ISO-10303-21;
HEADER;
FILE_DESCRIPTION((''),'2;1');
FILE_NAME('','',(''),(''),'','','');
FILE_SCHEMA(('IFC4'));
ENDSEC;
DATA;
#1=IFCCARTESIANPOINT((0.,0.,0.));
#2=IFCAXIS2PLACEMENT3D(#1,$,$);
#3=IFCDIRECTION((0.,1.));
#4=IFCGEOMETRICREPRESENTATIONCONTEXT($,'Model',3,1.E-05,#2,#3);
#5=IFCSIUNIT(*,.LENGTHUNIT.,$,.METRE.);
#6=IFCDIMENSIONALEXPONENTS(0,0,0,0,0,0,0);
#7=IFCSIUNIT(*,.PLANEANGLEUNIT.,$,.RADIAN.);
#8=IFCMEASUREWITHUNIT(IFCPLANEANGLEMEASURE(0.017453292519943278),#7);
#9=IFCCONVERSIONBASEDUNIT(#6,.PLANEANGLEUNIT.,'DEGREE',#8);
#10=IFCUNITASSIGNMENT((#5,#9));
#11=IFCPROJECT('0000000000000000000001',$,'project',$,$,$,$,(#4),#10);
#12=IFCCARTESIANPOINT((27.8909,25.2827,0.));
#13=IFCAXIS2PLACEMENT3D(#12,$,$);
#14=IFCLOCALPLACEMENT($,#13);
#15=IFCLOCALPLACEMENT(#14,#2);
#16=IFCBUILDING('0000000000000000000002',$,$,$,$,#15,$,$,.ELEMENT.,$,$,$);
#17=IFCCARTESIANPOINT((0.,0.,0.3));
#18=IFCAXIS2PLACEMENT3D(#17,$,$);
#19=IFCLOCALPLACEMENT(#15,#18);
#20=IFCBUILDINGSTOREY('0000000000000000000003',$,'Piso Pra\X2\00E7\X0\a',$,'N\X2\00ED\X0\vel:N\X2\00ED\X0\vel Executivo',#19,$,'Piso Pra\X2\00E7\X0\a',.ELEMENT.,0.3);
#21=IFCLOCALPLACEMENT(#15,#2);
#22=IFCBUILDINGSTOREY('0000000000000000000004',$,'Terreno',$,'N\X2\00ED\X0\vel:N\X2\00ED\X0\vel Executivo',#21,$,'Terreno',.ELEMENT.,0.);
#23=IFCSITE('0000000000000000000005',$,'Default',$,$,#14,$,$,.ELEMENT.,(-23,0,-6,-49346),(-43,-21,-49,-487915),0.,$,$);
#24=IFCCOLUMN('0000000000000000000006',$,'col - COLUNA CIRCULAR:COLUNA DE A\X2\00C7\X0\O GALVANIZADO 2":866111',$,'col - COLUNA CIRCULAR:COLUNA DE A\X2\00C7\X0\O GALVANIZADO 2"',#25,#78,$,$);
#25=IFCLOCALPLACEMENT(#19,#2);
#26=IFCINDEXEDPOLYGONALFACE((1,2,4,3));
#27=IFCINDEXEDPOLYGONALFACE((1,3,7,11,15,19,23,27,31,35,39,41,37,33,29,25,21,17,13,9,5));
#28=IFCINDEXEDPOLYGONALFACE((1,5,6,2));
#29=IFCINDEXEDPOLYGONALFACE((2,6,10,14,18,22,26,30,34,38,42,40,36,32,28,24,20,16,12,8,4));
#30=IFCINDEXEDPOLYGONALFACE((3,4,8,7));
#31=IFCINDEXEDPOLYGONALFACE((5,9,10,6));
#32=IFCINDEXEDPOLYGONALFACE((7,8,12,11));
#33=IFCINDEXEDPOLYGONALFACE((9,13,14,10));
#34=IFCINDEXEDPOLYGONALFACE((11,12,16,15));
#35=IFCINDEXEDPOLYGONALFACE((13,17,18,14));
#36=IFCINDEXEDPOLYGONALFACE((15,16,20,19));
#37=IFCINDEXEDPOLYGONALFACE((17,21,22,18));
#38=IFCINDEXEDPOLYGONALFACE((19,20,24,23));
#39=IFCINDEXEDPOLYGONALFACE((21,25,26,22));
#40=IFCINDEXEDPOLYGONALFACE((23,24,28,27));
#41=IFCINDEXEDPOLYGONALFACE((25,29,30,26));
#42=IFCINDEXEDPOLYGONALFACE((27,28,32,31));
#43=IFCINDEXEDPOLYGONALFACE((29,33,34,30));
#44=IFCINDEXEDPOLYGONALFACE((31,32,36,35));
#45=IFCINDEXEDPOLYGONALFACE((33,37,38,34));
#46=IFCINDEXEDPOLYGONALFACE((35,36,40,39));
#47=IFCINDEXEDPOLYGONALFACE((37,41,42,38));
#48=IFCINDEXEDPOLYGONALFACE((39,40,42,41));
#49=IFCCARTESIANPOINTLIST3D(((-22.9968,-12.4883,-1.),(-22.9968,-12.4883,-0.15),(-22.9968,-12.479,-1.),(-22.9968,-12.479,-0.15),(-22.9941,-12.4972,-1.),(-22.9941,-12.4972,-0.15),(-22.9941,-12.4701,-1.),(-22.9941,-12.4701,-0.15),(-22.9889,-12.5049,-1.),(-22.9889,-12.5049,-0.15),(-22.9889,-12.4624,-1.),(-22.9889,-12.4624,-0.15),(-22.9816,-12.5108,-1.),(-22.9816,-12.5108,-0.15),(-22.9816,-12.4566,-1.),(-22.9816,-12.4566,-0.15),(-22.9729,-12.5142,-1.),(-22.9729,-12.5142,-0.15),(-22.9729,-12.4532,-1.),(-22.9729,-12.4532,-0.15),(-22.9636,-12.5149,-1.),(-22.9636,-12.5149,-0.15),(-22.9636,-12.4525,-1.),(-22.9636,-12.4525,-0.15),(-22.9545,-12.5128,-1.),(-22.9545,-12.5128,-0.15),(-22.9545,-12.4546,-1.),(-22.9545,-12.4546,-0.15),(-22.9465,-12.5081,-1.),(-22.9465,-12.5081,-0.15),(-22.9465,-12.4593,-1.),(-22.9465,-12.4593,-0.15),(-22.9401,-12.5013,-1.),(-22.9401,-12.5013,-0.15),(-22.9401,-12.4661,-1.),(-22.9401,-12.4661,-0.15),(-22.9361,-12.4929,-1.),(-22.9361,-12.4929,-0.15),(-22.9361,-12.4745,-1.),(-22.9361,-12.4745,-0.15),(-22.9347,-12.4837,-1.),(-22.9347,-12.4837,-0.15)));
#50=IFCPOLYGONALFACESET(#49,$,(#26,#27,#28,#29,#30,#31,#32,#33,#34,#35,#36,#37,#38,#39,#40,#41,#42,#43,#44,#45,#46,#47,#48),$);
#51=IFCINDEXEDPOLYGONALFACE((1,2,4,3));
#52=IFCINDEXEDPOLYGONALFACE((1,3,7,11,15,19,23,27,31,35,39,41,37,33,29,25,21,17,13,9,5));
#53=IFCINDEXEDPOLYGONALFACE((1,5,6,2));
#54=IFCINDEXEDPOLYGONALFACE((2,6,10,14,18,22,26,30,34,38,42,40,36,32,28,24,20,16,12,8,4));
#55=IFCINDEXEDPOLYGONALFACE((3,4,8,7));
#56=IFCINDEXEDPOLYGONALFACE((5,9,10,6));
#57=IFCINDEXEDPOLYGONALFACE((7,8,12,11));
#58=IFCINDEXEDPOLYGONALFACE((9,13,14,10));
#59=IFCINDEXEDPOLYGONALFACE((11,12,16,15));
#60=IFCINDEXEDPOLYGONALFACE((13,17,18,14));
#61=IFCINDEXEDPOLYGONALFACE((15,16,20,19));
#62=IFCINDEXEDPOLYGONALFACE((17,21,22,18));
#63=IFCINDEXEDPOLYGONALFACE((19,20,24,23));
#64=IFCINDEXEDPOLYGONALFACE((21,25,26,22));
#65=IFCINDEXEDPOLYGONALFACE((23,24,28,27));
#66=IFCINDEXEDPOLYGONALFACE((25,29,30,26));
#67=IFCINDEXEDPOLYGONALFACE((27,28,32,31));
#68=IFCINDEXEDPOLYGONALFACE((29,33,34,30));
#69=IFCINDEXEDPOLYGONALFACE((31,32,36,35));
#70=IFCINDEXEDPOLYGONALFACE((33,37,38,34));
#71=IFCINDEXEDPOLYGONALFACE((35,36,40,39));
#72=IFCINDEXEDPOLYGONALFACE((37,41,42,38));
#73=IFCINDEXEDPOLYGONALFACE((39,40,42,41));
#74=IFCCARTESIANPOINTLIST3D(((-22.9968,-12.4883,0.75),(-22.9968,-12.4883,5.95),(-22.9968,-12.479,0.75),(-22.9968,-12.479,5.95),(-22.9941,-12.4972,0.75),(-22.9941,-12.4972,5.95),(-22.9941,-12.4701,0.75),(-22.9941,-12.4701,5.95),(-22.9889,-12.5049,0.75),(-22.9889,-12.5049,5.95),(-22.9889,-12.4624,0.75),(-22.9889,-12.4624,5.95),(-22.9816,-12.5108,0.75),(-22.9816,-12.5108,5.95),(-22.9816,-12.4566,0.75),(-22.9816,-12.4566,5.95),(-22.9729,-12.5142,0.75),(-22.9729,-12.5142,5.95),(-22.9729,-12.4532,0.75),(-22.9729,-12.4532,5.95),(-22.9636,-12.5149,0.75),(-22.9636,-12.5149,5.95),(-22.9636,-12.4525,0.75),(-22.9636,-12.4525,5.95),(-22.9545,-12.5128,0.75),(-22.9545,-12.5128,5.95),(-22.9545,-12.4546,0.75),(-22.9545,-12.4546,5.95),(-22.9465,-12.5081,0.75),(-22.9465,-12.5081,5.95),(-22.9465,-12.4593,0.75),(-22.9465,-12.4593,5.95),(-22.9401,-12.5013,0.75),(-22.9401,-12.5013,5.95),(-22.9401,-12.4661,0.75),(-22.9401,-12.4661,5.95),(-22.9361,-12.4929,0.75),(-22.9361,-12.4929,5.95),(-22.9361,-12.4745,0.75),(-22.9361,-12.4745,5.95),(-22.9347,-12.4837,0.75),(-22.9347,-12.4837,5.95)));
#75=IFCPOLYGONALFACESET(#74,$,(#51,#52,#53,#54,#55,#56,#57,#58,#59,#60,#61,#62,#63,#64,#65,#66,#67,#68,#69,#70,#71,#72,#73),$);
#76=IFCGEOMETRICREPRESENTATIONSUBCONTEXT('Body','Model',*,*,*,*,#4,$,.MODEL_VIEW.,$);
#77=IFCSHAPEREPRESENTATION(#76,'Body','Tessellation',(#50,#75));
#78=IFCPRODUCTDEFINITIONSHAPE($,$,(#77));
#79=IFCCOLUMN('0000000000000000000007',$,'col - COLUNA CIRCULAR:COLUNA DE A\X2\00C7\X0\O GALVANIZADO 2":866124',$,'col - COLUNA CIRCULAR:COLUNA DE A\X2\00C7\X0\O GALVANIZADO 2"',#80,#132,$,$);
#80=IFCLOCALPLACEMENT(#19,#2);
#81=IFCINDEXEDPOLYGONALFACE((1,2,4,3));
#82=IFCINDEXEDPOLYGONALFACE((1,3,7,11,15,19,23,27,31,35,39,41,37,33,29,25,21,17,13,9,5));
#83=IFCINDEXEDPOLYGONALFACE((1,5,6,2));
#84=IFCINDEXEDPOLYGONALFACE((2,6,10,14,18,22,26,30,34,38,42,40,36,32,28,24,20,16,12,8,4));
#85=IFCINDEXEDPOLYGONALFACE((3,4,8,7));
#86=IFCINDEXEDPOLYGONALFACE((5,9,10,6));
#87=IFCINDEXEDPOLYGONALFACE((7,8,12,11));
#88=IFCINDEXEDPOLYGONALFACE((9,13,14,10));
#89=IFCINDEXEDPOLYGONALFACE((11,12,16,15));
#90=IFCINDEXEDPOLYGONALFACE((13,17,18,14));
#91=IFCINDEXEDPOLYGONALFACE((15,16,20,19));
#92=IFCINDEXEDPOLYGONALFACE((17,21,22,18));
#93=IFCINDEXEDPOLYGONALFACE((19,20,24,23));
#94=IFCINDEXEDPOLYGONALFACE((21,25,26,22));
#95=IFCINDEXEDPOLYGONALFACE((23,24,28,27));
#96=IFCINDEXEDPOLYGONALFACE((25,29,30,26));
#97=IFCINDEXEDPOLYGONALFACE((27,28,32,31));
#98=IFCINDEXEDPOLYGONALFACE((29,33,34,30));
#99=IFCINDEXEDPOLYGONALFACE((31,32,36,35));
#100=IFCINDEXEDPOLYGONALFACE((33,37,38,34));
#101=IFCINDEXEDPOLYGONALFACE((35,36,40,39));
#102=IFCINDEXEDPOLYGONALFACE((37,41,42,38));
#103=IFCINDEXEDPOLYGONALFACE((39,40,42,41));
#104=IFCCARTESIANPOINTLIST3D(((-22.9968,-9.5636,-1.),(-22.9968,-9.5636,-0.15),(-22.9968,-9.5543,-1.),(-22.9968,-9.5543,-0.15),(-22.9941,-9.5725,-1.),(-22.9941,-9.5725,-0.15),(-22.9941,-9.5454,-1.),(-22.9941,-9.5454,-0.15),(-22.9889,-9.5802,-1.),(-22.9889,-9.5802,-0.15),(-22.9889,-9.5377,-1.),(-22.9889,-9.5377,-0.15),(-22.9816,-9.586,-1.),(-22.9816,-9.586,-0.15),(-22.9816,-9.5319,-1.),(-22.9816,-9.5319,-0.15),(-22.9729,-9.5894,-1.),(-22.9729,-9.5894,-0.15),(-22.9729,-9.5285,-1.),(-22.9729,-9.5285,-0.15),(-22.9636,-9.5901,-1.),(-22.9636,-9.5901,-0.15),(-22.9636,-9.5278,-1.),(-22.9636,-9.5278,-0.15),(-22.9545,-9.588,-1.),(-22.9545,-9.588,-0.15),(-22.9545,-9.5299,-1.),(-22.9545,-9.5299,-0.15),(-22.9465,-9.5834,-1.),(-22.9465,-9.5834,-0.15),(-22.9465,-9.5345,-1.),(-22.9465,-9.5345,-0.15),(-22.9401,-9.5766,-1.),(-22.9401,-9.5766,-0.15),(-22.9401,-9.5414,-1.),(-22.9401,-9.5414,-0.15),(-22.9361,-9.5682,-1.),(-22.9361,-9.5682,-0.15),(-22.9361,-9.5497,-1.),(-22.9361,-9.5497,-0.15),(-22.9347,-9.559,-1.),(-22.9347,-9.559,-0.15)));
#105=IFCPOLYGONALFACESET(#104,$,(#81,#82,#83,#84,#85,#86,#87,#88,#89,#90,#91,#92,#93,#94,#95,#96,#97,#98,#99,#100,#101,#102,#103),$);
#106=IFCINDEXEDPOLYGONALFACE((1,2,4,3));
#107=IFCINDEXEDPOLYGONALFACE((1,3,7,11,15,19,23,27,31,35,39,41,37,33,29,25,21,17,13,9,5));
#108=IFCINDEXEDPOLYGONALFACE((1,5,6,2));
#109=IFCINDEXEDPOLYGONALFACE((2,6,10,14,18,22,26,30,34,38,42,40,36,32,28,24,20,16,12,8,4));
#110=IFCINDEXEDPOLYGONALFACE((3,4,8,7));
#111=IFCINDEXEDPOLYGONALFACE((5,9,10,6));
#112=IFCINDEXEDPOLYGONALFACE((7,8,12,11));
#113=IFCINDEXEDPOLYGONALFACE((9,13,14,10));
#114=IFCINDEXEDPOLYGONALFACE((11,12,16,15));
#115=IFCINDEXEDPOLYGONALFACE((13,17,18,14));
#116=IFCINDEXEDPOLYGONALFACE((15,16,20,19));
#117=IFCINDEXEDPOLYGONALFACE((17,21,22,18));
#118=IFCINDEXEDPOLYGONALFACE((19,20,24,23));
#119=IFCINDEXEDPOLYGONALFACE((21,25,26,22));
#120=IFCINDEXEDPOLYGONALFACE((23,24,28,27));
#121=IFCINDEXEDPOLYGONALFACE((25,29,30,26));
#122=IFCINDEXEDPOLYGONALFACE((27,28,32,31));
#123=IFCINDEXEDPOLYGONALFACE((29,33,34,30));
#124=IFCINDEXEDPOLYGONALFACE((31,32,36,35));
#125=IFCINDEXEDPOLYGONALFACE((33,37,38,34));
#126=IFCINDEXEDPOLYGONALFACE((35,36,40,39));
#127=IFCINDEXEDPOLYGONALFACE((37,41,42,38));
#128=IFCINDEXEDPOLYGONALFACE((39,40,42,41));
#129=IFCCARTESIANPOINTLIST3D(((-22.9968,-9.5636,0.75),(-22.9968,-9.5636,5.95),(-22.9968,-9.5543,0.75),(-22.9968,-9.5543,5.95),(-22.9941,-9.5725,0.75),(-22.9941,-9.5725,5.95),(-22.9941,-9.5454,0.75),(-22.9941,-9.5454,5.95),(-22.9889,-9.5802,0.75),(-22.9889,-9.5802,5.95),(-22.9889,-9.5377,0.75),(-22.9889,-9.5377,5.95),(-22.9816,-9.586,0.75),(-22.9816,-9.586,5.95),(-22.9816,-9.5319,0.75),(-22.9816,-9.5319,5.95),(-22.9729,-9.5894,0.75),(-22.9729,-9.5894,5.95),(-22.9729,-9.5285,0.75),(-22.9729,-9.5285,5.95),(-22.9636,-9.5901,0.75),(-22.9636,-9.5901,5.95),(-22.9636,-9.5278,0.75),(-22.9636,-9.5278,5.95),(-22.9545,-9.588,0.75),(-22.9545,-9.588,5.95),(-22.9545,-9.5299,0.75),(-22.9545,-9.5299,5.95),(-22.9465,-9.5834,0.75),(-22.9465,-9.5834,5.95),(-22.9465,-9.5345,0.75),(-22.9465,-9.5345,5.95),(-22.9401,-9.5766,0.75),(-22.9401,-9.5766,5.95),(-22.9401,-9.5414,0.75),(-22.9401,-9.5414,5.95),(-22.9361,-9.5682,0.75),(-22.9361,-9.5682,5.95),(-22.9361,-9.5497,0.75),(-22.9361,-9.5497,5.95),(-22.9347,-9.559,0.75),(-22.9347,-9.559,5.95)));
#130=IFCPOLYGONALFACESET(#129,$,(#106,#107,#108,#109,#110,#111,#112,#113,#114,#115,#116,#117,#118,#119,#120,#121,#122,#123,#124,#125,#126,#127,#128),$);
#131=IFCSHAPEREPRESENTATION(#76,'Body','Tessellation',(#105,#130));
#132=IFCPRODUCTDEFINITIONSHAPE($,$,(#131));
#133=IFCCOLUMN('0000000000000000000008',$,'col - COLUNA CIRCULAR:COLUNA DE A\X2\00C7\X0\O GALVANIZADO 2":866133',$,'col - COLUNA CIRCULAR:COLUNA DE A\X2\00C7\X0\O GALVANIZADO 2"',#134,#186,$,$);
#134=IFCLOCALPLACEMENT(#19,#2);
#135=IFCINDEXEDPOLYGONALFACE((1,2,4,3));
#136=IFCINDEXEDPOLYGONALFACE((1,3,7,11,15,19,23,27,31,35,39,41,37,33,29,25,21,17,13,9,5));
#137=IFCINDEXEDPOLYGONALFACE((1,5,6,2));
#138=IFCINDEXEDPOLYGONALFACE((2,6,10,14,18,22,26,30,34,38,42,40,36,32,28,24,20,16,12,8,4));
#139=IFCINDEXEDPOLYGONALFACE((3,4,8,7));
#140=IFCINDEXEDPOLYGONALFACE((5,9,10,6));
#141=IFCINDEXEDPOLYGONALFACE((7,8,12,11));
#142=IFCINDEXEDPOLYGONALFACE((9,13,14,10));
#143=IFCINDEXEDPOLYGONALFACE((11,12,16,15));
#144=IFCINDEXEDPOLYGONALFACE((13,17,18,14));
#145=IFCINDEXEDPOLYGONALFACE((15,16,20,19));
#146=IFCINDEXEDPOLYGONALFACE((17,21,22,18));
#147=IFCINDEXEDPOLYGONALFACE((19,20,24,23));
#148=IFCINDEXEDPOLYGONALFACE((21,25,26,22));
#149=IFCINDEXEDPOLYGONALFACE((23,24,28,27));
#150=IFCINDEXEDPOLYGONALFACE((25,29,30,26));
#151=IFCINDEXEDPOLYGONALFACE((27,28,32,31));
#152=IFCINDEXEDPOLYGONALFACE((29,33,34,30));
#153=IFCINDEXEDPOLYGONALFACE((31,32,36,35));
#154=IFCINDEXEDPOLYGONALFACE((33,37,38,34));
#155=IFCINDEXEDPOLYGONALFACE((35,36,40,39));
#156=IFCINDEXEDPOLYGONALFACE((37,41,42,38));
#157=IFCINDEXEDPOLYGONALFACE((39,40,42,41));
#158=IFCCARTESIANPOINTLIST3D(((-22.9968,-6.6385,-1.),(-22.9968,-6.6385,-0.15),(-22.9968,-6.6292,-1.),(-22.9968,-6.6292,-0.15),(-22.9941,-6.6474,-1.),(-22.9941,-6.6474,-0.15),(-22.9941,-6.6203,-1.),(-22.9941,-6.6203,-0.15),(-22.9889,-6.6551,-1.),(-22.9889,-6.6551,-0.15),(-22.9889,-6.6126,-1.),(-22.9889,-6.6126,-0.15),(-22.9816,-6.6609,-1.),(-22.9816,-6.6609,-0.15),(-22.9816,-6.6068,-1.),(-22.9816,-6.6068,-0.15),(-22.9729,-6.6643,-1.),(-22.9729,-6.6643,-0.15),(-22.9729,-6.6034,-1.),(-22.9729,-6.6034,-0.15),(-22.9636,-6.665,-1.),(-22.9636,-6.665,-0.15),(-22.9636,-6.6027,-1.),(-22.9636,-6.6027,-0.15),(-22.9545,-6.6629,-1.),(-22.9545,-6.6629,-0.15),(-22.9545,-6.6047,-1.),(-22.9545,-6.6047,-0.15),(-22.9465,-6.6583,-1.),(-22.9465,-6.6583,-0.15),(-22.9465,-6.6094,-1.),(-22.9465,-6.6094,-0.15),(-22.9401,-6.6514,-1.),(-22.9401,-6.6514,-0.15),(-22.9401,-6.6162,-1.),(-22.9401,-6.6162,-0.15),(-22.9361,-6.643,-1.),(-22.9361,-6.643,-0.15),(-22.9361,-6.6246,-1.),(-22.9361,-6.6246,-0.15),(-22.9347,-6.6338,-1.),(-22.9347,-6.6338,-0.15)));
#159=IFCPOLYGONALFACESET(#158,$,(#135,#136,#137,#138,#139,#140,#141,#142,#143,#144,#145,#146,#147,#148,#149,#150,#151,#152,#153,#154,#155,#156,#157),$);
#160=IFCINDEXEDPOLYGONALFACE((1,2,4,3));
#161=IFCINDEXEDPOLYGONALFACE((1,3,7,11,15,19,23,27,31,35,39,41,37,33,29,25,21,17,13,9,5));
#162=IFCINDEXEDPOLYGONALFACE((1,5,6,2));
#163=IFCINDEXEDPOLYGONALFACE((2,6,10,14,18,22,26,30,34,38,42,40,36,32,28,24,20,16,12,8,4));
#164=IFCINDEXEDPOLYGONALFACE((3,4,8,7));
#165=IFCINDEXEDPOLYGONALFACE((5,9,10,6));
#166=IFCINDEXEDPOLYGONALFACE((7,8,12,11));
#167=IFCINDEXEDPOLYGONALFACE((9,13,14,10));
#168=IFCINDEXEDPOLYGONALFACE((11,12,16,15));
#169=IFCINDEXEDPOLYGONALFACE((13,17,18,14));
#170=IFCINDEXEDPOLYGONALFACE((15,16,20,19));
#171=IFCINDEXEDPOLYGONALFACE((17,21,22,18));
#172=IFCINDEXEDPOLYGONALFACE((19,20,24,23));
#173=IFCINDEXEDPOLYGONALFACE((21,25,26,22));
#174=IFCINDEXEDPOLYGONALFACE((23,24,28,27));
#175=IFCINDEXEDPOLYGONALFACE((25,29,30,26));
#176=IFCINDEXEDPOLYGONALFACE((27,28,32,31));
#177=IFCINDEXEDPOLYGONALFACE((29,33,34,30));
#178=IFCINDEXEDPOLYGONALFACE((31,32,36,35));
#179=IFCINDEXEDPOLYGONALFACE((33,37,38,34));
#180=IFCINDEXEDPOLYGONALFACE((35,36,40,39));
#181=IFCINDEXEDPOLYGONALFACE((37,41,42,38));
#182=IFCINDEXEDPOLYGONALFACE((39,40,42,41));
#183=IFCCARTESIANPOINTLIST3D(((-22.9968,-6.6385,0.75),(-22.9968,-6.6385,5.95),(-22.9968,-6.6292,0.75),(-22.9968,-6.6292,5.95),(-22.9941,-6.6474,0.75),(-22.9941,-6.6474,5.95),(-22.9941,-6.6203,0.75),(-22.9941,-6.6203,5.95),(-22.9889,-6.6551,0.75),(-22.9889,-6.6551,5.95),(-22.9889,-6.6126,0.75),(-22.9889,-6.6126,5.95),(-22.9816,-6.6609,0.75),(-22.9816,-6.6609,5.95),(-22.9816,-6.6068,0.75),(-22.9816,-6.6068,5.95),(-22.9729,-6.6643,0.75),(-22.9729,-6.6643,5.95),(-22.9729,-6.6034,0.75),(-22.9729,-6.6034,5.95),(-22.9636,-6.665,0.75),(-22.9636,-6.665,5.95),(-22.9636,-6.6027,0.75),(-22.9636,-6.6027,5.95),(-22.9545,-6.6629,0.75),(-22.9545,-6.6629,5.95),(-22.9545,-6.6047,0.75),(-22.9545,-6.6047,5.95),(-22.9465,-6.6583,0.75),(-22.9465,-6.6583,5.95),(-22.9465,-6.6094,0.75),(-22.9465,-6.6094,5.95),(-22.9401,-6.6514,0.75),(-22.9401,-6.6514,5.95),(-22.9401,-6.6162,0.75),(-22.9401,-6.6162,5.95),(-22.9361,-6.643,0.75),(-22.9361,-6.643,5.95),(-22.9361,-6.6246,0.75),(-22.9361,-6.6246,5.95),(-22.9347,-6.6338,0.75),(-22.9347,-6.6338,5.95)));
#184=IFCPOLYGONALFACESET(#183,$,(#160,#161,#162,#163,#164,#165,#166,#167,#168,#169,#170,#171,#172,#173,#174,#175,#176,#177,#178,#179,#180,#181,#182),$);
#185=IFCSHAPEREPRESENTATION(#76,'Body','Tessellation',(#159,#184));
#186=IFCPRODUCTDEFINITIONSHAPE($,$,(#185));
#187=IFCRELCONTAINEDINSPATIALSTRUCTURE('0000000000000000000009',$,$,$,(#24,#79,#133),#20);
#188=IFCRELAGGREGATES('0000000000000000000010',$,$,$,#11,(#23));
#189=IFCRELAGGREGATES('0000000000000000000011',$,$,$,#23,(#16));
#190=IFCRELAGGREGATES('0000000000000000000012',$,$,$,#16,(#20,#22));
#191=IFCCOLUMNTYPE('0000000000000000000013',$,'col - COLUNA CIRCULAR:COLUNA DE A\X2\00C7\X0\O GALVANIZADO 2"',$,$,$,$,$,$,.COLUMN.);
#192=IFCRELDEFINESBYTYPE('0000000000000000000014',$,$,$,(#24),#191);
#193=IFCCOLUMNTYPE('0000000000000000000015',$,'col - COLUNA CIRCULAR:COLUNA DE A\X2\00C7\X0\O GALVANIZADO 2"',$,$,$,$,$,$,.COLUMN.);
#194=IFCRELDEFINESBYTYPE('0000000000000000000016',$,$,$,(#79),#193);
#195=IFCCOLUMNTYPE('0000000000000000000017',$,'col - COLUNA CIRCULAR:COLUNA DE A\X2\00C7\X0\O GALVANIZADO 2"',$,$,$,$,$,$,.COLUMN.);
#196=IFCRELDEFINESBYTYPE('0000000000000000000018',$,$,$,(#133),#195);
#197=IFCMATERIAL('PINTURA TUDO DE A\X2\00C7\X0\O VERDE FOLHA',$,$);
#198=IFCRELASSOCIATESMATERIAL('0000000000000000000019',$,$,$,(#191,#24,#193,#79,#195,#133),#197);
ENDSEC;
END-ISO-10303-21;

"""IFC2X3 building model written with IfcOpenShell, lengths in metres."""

from ifc_helpers import new_model, entity, si_unit, converted_unit, direction, frame, origin, origin_2d_with_axis, place, context, subcontext, project, spatial, circle, extrude, source, transform, mapped, material, type_object, type_shapes, element, save


model = new_model("IFC2X3")

# Units and contexts
model_context = context("Model", 3, precision=1e-05, world=origin(), true_north=direction((0.0, 1.0)))
body_context = subcontext(model_context, "Body", "Model", "MODEL_VIEW")
ifc_project = project(units=[si_unit("LENGTHUNIT", "METRE"), converted_unit("PLANEANGLEUNIT", "DEGREE", entity("IfcPlaneAngleMeasure", 0.017453292519943278), si_unit("PLANEANGLEUNIT", "RADIAN"), dimensions=[0, 0, 0, 0, 0, 0, 0])], contexts=[model_context])

# Site, building, storey
site_placement = place(None, frame((27.8909, 25.2827, 0.0)))
site = spatial("IfcSite", under=ifc_project, at=site_placement, Name="Default", CompositionType="ELEMENT", RefLatitude=(-23, 0, -6, -49346), RefLongitude=(-43, -21, -49, -487915), RefElevation=0.0)
building_placement = place(site_placement, origin())
building = spatial("IfcBuilding", under=site, at=building_placement, CompositionType="ELEMENT")
storey_1_placement = place(building_placement, frame((0.0, 0.0, 0.3)))
storey_1 = spatial("IfcBuildingStorey", under=building, at=storey_1_placement, Name="Piso Praça", ObjectType="Nível:Nível Executivo", LongName="Piso Praça", CompositionType="ELEMENT", Elevation=0.3)

# Columns
ifc_material_1 = material(Name="PINTURA TUDO DE AÇO VERDE FOLHA")
column_type_1 = type_object("IfcColumnType", Name="col - COLUNA CIRCULAR:COLUNA DE AÇO GALVANIZADO 2\"", PredefinedType="COLUMN", material=ifc_material_1)
shared_shape_1 = source(origin(), body_context, "Body", "SweptSolid", [
    extrude(circle(Radius=0.0312, at=origin_2d_with_axis()), frame((-22.9659, -12.4837, -0.7)), (0.0, 0.0, 1.0), 0.85),
    extrude(circle(Radius=0.0312, at=origin_2d_with_axis()), frame((-22.9659, -12.4837, 1.05)), (0.0, 0.0, 1.0), 5.2),
])
type_shapes(column_type_1, [shared_shape_1])
column_1_placement = place(storey_1_placement, frame((0.0, 0.0, -0.3)))
element("IfcColumn", 1, at=column_1_placement, inside=storey_1, type_object=column_type_1, material=ifc_material_1, Name="col - COLUNA CIRCULAR:COLUNA DE AÇO GALVANIZADO 2\":866111", ObjectType="col - COLUNA CIRCULAR:COLUNA DE AÇO GALVANIZADO 2\"", context=body_context, shape_type="MappedRepresentation", body=[
    mapped(shared_shape_1, transform((0.0, 0.0, 0.0), scale=1.0)),
])
column_type_2 = type_object("IfcColumnType", Name="col - COLUNA CIRCULAR:COLUNA DE AÇO GALVANIZADO 2\"", PredefinedType="COLUMN", material=ifc_material_1)
shared_shape_2 = source(origin(), body_context, "Body", "SweptSolid", [
    extrude(circle(Radius=0.0312, at=origin_2d_with_axis()), frame((-22.9659, -9.559, -0.7)), (0.0, 0.0, 1.0), 0.85),
    extrude(circle(Radius=0.0312, at=origin_2d_with_axis()), frame((-22.9659, -9.559, 1.05)), (0.0, 0.0, 1.0), 5.2),
])
type_shapes(column_type_2, [shared_shape_2])
column_2_placement = place(storey_1_placement, frame((0.0, 0.0, -0.3)))
element("IfcColumn", 2, at=column_2_placement, inside=storey_1, type_object=column_type_2, material=ifc_material_1, Name="col - COLUNA CIRCULAR:COLUNA DE AÇO GALVANIZADO 2\":866124", ObjectType="col - COLUNA CIRCULAR:COLUNA DE AÇO GALVANIZADO 2\"", context=body_context, shape_type="MappedRepresentation", body=[
    mapped(shared_shape_2, transform((0.0, 0.0, 0.0), scale=1.0)),
])
column_type_3 = type_object("IfcColumnType", Name="col - COLUNA CIRCULAR:COLUNA DE AÇO GALVANIZADO 2\"", PredefinedType="COLUMN", material=ifc_material_1)
shared_shape_3 = source(origin(), body_context, "Body", "SweptSolid", [
    extrude(circle(Radius=0.0312, at=origin_2d_with_axis()), frame((-22.9659, -6.6338, -0.7)), (0.0, 0.0, 1.0), 0.85),
    extrude(circle(Radius=0.0312, at=origin_2d_with_axis()), frame((-22.9659, -6.6338, 1.05)), (0.0, 0.0, 1.0), 5.2),
])
type_shapes(column_type_3, [shared_shape_3])
column_3_placement = place(storey_1_placement, frame((0.0, 0.0, -0.3)))
element("IfcColumn", 3, at=column_3_placement, inside=storey_1, type_object=column_type_3, material=ifc_material_1, Name="col - COLUNA CIRCULAR:COLUNA DE AÇO GALVANIZADO 2\":866133", ObjectType="col - COLUNA CIRCULAR:COLUNA DE AÇO GALVANIZADO 2\"", context=body_context, shape_type="MappedRepresentation", body=[
    mapped(shared_shape_3, transform((0.0, 0.0, 0.0), scale=1.0)),
])

# Shared definitions
storey_2_placement = place(building_placement, origin())
storey_2 = spatial("IfcBuildingStorey", under=building, at=storey_2_placement, Name="Terreno", ObjectType="Nível:Nível Executivo", LongName="Terreno", CompositionType="ELEMENT", Elevation=0.0)

save(model, "model.ifc")
